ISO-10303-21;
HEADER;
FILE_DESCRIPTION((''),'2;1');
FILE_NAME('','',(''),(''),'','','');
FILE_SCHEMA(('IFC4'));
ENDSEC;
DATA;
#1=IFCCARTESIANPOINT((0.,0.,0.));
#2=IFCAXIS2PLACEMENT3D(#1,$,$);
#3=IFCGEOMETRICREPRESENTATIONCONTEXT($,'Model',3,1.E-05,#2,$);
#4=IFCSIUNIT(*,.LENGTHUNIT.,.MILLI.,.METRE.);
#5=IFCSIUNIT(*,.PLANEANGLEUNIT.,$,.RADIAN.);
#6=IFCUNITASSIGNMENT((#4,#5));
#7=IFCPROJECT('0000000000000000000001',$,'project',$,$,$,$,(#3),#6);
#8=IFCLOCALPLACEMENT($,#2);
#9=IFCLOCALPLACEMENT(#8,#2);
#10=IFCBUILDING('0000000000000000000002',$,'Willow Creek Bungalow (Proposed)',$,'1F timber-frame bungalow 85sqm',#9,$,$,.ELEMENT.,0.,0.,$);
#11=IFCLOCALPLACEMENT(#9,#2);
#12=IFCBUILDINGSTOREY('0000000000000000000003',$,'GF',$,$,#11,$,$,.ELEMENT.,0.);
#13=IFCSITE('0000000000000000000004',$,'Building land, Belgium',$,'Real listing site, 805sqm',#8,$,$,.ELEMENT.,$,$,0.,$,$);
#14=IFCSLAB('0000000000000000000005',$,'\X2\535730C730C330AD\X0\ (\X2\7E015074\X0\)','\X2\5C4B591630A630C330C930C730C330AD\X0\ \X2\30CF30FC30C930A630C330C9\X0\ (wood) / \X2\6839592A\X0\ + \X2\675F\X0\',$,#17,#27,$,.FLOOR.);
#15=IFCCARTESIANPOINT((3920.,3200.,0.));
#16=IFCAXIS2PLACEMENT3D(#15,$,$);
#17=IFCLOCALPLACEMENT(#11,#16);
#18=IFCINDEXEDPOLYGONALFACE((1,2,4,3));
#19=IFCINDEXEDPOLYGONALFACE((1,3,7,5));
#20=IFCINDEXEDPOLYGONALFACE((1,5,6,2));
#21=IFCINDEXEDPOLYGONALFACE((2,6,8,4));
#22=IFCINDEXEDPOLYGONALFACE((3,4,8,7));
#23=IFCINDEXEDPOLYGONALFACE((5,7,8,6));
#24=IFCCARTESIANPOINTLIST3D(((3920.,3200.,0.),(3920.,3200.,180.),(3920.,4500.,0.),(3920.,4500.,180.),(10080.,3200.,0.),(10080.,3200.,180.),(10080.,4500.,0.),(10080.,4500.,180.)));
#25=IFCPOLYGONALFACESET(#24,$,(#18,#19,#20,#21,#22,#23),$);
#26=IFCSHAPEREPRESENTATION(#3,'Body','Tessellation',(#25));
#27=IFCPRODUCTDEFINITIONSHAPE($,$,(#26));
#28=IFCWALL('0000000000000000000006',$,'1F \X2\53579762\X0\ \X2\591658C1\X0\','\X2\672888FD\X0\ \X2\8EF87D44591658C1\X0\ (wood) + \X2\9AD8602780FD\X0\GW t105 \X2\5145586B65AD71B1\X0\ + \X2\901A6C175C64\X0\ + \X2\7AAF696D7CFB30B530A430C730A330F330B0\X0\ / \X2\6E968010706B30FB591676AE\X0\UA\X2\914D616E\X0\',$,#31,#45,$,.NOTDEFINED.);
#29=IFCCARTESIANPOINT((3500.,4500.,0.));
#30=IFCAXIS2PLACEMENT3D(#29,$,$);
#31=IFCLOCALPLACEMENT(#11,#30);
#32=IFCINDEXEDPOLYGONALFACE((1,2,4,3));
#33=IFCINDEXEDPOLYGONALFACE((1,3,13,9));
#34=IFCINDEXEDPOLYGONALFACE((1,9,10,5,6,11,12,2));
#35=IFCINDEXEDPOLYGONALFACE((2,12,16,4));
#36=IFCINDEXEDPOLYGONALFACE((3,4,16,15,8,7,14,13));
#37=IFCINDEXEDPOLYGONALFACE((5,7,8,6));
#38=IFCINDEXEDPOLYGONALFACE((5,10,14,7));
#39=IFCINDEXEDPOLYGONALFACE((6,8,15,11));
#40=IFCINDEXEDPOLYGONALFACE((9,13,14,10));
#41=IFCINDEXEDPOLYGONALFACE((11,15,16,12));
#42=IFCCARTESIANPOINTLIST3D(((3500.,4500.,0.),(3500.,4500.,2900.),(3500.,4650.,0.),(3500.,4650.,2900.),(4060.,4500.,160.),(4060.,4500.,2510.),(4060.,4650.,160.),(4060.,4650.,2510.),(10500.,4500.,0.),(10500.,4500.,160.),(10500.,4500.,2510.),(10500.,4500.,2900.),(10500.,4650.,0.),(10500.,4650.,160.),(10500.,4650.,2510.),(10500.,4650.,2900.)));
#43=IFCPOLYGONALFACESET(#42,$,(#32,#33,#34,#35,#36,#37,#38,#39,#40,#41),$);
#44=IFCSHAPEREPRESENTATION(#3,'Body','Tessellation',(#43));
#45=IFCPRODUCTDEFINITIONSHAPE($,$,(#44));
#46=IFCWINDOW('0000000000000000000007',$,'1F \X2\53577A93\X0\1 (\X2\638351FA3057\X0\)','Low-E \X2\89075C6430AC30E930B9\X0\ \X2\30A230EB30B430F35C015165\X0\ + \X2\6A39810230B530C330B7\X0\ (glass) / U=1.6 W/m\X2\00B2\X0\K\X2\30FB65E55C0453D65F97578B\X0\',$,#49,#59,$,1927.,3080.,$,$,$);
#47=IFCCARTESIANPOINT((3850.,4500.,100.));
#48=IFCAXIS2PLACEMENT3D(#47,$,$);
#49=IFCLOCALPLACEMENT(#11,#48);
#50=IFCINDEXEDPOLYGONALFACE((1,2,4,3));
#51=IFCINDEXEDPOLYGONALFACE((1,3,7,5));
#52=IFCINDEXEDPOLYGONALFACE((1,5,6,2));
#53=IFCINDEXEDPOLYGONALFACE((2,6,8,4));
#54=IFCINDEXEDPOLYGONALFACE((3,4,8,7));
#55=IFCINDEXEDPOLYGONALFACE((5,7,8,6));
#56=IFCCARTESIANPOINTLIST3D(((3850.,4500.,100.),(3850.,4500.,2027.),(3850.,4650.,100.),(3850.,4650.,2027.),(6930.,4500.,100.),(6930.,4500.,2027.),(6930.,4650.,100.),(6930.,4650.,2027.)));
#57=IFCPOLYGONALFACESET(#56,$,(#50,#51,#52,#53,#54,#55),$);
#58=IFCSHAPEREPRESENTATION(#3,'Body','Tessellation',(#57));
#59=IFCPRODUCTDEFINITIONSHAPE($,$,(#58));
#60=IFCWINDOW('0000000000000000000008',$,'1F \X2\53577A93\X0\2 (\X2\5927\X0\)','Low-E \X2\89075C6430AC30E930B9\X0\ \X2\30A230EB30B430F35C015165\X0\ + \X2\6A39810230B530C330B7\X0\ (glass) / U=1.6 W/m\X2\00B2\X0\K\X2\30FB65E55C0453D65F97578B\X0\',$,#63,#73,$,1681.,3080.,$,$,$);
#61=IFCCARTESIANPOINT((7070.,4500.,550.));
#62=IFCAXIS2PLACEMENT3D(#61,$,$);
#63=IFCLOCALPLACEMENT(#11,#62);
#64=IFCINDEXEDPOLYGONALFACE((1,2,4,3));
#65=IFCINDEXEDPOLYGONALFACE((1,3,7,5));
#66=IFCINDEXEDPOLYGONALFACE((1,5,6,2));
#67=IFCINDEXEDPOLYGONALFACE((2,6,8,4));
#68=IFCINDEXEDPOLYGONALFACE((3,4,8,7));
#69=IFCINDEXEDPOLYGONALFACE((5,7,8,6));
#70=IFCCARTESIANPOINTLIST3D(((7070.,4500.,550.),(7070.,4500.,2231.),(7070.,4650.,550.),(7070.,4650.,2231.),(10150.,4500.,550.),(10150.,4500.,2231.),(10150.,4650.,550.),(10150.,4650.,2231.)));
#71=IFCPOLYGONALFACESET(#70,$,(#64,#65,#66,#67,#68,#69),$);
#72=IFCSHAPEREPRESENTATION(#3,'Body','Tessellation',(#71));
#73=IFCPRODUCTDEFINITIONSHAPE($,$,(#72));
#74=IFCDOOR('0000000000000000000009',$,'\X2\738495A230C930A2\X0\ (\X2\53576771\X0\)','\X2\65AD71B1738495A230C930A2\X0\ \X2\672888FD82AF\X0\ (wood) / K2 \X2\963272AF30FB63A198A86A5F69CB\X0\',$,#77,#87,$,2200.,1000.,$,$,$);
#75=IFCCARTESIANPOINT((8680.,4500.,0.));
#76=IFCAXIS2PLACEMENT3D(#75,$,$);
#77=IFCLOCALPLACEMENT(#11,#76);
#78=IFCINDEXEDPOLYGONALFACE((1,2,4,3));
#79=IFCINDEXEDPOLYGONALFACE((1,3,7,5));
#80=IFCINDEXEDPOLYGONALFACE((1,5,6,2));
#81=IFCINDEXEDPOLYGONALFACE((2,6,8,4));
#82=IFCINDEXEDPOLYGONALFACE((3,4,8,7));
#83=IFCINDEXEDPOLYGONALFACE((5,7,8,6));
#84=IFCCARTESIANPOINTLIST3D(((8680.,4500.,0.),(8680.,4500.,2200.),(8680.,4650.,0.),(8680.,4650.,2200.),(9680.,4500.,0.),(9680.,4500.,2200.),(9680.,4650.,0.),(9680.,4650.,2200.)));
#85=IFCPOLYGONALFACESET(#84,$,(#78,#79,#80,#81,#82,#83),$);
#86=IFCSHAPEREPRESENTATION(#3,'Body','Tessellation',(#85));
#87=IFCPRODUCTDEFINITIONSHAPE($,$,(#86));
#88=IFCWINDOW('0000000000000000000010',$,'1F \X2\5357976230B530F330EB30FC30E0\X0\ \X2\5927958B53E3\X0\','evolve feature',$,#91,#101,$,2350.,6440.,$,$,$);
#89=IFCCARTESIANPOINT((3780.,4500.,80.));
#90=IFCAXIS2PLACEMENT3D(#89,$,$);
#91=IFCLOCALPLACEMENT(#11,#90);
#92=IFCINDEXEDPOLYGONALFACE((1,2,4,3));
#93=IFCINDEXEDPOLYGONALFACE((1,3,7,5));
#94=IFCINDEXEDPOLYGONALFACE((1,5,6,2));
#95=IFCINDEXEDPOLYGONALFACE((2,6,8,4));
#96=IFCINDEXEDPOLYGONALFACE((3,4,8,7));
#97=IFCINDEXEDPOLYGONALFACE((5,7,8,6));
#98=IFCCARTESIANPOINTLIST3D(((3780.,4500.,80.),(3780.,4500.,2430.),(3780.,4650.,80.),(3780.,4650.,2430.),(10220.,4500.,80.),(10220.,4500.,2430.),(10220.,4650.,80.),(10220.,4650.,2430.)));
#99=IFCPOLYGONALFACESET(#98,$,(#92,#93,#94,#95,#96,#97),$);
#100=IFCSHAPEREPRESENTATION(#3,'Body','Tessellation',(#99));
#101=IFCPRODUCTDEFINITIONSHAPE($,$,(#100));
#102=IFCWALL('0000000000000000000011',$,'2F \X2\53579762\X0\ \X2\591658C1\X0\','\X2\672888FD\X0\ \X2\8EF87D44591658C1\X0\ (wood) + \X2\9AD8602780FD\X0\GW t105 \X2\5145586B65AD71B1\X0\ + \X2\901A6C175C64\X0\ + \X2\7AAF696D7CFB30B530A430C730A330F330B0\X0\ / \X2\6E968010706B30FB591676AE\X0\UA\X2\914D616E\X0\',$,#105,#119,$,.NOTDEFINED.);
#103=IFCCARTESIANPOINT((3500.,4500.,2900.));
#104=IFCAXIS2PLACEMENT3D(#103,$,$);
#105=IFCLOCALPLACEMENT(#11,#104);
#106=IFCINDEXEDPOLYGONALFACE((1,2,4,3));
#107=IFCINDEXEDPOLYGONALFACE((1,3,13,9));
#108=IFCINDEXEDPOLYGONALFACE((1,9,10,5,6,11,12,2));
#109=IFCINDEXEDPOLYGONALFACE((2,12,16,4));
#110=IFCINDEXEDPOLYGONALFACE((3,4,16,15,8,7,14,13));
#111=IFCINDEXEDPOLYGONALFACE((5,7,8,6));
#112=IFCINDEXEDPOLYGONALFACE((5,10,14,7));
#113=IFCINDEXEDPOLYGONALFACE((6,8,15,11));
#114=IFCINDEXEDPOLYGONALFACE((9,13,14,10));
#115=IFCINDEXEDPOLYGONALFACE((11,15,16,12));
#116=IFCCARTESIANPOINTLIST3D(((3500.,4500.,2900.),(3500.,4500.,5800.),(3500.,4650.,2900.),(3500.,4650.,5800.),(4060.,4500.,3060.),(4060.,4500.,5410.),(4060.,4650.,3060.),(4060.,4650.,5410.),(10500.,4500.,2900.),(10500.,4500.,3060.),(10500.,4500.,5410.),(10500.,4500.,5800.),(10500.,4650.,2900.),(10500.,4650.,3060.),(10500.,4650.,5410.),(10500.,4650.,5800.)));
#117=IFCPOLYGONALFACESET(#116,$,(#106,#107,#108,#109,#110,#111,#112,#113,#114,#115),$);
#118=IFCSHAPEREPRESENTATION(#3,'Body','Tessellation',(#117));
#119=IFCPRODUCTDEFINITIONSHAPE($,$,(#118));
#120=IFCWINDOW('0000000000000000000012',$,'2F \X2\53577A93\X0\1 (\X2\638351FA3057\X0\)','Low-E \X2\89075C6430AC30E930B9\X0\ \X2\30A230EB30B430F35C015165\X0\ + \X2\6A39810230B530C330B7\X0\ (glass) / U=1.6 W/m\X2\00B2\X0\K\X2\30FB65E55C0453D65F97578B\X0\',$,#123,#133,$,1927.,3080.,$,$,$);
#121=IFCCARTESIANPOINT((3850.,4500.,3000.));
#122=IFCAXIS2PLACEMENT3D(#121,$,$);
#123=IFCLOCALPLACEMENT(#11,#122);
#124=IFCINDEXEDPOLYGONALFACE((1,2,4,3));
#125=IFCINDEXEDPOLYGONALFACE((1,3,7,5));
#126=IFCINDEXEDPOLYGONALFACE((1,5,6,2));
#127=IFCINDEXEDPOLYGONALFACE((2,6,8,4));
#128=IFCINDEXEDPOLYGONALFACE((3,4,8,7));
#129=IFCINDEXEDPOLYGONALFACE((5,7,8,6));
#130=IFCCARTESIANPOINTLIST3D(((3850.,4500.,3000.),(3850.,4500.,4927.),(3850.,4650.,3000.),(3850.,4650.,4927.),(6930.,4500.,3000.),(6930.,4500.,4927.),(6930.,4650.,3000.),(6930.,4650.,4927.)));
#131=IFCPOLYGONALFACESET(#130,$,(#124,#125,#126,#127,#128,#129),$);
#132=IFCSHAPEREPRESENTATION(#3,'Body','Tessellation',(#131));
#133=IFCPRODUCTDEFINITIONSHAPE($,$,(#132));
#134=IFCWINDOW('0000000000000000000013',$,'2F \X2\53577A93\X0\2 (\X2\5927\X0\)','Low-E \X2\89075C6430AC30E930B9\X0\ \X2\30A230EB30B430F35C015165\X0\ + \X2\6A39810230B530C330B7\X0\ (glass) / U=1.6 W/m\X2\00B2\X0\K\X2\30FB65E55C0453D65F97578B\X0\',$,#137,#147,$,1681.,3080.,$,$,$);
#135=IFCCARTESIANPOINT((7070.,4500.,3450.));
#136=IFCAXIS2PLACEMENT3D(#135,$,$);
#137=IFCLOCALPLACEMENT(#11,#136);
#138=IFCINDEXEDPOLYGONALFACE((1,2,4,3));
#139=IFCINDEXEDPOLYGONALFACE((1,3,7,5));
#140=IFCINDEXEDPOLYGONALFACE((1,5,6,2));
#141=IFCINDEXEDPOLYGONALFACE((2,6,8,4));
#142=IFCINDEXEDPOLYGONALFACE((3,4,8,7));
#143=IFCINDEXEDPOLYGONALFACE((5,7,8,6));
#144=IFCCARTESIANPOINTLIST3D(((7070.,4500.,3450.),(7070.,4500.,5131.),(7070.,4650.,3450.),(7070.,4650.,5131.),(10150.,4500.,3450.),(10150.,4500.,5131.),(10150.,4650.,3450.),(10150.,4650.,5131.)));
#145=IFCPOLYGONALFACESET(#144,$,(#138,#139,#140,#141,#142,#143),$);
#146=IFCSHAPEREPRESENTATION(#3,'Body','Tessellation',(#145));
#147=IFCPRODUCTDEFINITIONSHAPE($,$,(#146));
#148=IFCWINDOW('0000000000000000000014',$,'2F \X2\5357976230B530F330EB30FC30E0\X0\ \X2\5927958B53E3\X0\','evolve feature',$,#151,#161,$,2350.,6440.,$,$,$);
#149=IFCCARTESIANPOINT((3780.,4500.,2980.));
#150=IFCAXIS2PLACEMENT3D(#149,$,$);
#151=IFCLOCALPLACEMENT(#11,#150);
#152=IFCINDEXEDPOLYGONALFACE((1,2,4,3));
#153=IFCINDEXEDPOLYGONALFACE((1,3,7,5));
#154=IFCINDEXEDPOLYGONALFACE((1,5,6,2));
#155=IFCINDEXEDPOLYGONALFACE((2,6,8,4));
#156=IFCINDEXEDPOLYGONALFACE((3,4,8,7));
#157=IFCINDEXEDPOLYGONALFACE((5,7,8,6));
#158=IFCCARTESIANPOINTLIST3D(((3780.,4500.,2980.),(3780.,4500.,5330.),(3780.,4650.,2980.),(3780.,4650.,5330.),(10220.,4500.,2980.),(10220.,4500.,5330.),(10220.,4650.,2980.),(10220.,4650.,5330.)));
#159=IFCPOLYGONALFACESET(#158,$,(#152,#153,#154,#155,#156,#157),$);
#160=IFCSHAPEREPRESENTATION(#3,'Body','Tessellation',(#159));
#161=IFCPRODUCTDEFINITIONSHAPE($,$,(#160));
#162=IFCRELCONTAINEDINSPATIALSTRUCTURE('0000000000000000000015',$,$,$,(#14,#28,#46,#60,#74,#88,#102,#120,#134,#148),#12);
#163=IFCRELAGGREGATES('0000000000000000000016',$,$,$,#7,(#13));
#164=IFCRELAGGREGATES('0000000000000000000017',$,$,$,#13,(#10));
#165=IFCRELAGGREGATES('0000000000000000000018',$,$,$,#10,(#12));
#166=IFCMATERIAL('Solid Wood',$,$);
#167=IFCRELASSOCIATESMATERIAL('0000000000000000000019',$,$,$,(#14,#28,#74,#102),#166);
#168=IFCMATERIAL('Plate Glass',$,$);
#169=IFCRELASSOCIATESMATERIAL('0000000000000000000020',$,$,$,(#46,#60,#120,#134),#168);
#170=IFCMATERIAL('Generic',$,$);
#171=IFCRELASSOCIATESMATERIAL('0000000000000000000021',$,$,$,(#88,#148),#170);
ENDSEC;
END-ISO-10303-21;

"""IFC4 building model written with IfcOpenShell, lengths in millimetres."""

from ifc_helpers import new_model, si_unit, frame, frame_2d, origin, place, context, project, spatial, rectangle, extrude, material, element, fill, save


model = new_model("IFC4")

# Units and contexts
model_context = context("Model", 3, precision=1e-05, world=origin())
ifc_project = project(units=[si_unit("LENGTHUNIT", "METRE", prefix="MILLI"), si_unit("PLANEANGLEUNIT", "RADIAN")], contexts=[model_context])

# Site, building, storey
site_placement = place(None, origin())
site = spatial("IfcSite", under=ifc_project, at=site_placement, Name="Building land, Belgium", ObjectType="Real listing site, 805sqm", CompositionType="ELEMENT", RefElevation=0.0)
building_placement = place(site_placement, origin())
building = spatial("IfcBuilding", under=site, at=building_placement, Name="Willow Creek Bungalow (Proposed)", ObjectType="1F timber-frame bungalow 85sqm", CompositionType="ELEMENT", ElevationOfRefHeight=0.0, ElevationOfTerrain=0.0)
storey_placement = place(building_placement, origin())
storey = spatial("IfcBuildingStorey", under=building, at=storey_placement, Name="GF", CompositionType="ELEMENT", Elevation=0.0)

# Slab
ifc_material_1 = material(Name="Solid Wood")
slab_1_placement = place(storey_placement, frame((3920.0, 3200.0, 0.0)))
element("IfcSlab", 1, at=slab_1_placement, inside=storey, material=ifc_material_1, Name="南デッキ (縁側)", Description="屋外ウッドデッキ ハードウッド (wood) / 根太 + 束", PredefinedType="FLOOR", context=model_context, shape_type="SweptSolid", body=[
    extrude(rectangle(XDim=6160.0, YDim=1300.0, at=frame_2d((3080.0, 650.0))), frame((3920.0, 3200.0, 0.0)), (0.0, 0.0, 1.0), 180.0),
])
ifc_material_2 = material(Name="Generic")

# Wall, openings, windows, door
wall_1_placement = place(storey_placement, frame((3500.0, 4500.0, 0.0)))
wall_1 = element("IfcWall", 2, at=wall_1_placement, inside=storey, material=ifc_material_1, Name="1F 南面 外壁", Description="木製 軸組外壁 (wood) + 高性能GW t105 充填断熱 + 通気層 + 窯業系サイディング / 準耐火・外皮UA配慮", PredefinedType="NOTDEFINED", context=model_context, shape_type="SweptSolid", body=[
    extrude(rectangle(XDim=7000.0, YDim=150.0, at=frame_2d((3500.0, 75.0))), frame((3500.0, 4500.0, 0.0)), (0.0, 0.0, 1.0), 2900.0),
])
opening_1_placement = place(storey_placement, frame((3850.0, 4500.0, 100.0)))
opening_1 = element("IfcOpeningElement", 3, at=opening_1_placement, cuts=wall_1, PredefinedType="NOTDEFINED", context=model_context, shape_type="SweptSolid", body=[
    extrude(rectangle(XDim=3080.0, YDim=150.0, at=frame_2d((1540.0, 75.0))), frame((3850.0, 4500.0, 100.0)), (0.0, 0.0, 1.0), 1927.0),
])
opening_2_placement = place(storey_placement, frame((7070.0, 4500.0, 550.0)))
opening_2 = element("IfcOpeningElement", 4, at=opening_2_placement, cuts=wall_1, PredefinedType="NOTDEFINED", context=model_context, shape_type="SweptSolid", body=[
    extrude(rectangle(XDim=3080.0, YDim=150.0, at=frame_2d((1540.0, 75.0))), frame((7070.0, 4500.0, 550.0)), (0.0, 0.0, 1.0), 1681.0),
])
opening_3_placement = place(storey_placement, frame((8680.0, 4500.0, 0.0)))
opening_3 = element("IfcOpeningElement", 5, at=opening_3_placement, cuts=wall_1, PredefinedType="NOTDEFINED", context=model_context, shape_type="SweptSolid", body=[
    extrude(rectangle(XDim=1000.0, YDim=150.0, at=frame_2d((500.0, 75.0))), frame((8680.0, 4500.0, 0.0)), (0.0, 0.0, 1.0), 2200.0),
])
opening_4_placement = place(storey_placement, frame((3780.0, 4500.0, 80.0)))
opening_4 = element("IfcOpeningElement", 6, at=opening_4_placement, cuts=wall_1, PredefinedType="NOTDEFINED", context=model_context, shape_type="SweptSolid", body=[
    extrude(rectangle(XDim=6440.0, YDim=150.0, at=frame_2d((3220.0, 75.0))), frame((3780.0, 4500.0, 80.0)), (0.0, 0.0, 1.0), 2350.0),
])
ifc_material_3 = material(Name="Plate Glass")
window_1_placement = place(storey_placement, frame((3850.0, 4500.0, 100.0)))
window_1 = element("IfcWindow", 7, at=window_1_placement, inside=storey, material=ifc_material_3, Name="1F 南窓1 (掃出し)", Description="Low-E 複層ガラス アルゴン封入 + 樹脂サッシ (glass) / U=1.6 W/m²K・日射取得型", OverallHeight=1927.0, OverallWidth=3080.0, context=model_context, shape_type="SweptSolid", body=[
    extrude(rectangle(XDim=3080.0, YDim=150.0, at=frame_2d((1540.0, 75.0))), frame((3850.0, 4500.0, 100.0)), (0.0, 0.0, 1.0), 1927.0),
])
fill(opening_1, window_1)
window_2_placement = place(storey_placement, frame((7070.0, 4500.0, 550.0)))
window_2 = element("IfcWindow", 8, at=window_2_placement, inside=storey, material=ifc_material_3, Name="1F 南窓2 (大)", Description="Low-E 複層ガラス アルゴン封入 + 樹脂サッシ (glass) / U=1.6 W/m²K・日射取得型", OverallHeight=1681.0, OverallWidth=3080.0, context=model_context, shape_type="SweptSolid", body=[
    extrude(rectangle(XDim=3080.0, YDim=150.0, at=frame_2d((1540.0, 75.0))), frame((7070.0, 4500.0, 550.0)), (0.0, 0.0, 1.0), 1681.0),
])
fill(opening_2, window_2)
door_placement = place(storey_placement, frame((8680.0, 4500.0, 0.0)))
door = element("IfcDoor", 9, at=door_placement, inside=storey, material=ifc_material_1, Name="玄関ドア (南東)", Description="断熱玄関ドア 木製芯 (wood) / K2 防犯・採風機構", OverallHeight=2200.0, OverallWidth=1000.0, context=model_context, shape_type="SweptSolid", body=[
    extrude(rectangle(XDim=1000.0, YDim=150.0, at=frame_2d((500.0, 75.0))), frame((8680.0, 4500.0, 0.0)), (0.0, 0.0, 1.0), 2200.0),
])
fill(opening_3, door)
window_3_placement = place(storey_placement, frame((3780.0, 4500.0, 80.0)))
window_3 = element("IfcWindow", 10, at=window_3_placement, inside=storey, material=ifc_material_2, Name="1F 南面サンルーム 大開口", Description="evolve feature", OverallHeight=2350.0, OverallWidth=6440.0, context=model_context, shape_type="SweptSolid", body=[
    extrude(rectangle(XDim=6440.0, YDim=150.0, at=frame_2d((3220.0, 75.0))), frame((3780.0, 4500.0, 80.0)), (0.0, 0.0, 1.0), 2350.0),
])
fill(opening_4, window_3)

# Wall, openings, windows
wall_2_placement = place(storey_placement, frame((3500.0, 4500.0, 2900.0)))
wall_2 = element("IfcWall", 11, at=wall_2_placement, inside=storey, material=ifc_material_1, Name="2F 南面 外壁", Description="木製 軸組外壁 (wood) + 高性能GW t105 充填断熱 + 通気層 + 窯業系サイディング / 準耐火・外皮UA配慮", PredefinedType="NOTDEFINED", context=model_context, shape_type="SweptSolid", body=[
    extrude(rectangle(XDim=7000.0, YDim=150.0, at=frame_2d((3500.0, 75.0))), frame((3500.0, 4500.0, 2900.0)), (0.0, 0.0, 1.0), 2900.0),
])
opening_5_placement = place(storey_placement, frame((3850.0, 4500.0, 3000.0)))
opening_5 = element("IfcOpeningElement", 12, at=opening_5_placement, cuts=wall_2, PredefinedType="NOTDEFINED", context=model_context, shape_type="SweptSolid", body=[
    extrude(rectangle(XDim=3080.0, YDim=150.0, at=frame_2d((1540.0, 75.0))), frame((3850.0, 4500.0, 3000.0)), (0.0, 0.0, 1.0), 1927.0),
])
opening_6_placement = place(storey_placement, frame((7070.0, 4500.0, 3450.0)))
opening_6 = element("IfcOpeningElement", 13, at=opening_6_placement, cuts=wall_2, PredefinedType="NOTDEFINED", context=model_context, shape_type="SweptSolid", body=[
    extrude(rectangle(XDim=3080.0, YDim=150.0, at=frame_2d((1540.0, 75.0))), frame((7070.0, 4500.0, 3450.0)), (0.0, 0.0, 1.0), 1681.0),
])
opening_7_placement = place(storey_placement, frame((3780.0, 4500.0, 2980.0)))
opening_7 = element("IfcOpeningElement", 14, at=opening_7_placement, cuts=wall_2, PredefinedType="NOTDEFINED", context=model_context, shape_type="SweptSolid", body=[
    extrude(rectangle(XDim=6440.0, YDim=150.0, at=frame_2d((3220.0, 75.0))), frame((3780.0, 4500.0, 2980.0)), (0.0, 0.0, 1.0), 2350.0),
])
window_4_placement = place(storey_placement, frame((3850.0, 4500.0, 3000.0)))
window_4 = element("IfcWindow", 15, at=window_4_placement, inside=storey, material=ifc_material_3, Name="2F 南窓1 (掃出し)", Description="Low-E 複層ガラス アルゴン封入 + 樹脂サッシ (glass) / U=1.6 W/m²K・日射取得型", OverallHeight=1927.0, OverallWidth=3080.0, context=model_context, shape_type="SweptSolid", body=[
    extrude(rectangle(XDim=3080.0, YDim=150.0, at=frame_2d((1540.0, 75.0))), frame((3850.0, 4500.0, 3000.0)), (0.0, 0.0, 1.0), 1927.0),
])
fill(opening_5, window_4)
window_5_placement = place(storey_placement, frame((7070.0, 4500.0, 3450.0)))
window_5 = element("IfcWindow", 16, at=window_5_placement, inside=storey, material=ifc_material_3, Name="2F 南窓2 (大)", Description="Low-E 複層ガラス アルゴン封入 + 樹脂サッシ (glass) / U=1.6 W/m²K・日射取得型", OverallHeight=1681.0, OverallWidth=3080.0, context=model_context, shape_type="SweptSolid", body=[
    extrude(rectangle(XDim=3080.0, YDim=150.0, at=frame_2d((1540.0, 75.0))), frame((7070.0, 4500.0, 3450.0)), (0.0, 0.0, 1.0), 1681.0),
])
fill(opening_6, window_5)
window_6_placement = place(storey_placement, frame((3780.0, 4500.0, 2980.0)))
window_6 = element("IfcWindow", 17, at=window_6_placement, inside=storey, material=ifc_material_2, Name="2F 南面サンルーム 大開口", Description="evolve feature", OverallHeight=2350.0, OverallWidth=6440.0, context=model_context, shape_type="SweptSolid", body=[
    extrude(rectangle(XDim=6440.0, YDim=150.0, at=frame_2d((3220.0, 75.0))), frame((3780.0, 4500.0, 2980.0)), (0.0, 0.0, 1.0), 2350.0),
])
fill(opening_7, window_6)

save(model, "model.ifc")
